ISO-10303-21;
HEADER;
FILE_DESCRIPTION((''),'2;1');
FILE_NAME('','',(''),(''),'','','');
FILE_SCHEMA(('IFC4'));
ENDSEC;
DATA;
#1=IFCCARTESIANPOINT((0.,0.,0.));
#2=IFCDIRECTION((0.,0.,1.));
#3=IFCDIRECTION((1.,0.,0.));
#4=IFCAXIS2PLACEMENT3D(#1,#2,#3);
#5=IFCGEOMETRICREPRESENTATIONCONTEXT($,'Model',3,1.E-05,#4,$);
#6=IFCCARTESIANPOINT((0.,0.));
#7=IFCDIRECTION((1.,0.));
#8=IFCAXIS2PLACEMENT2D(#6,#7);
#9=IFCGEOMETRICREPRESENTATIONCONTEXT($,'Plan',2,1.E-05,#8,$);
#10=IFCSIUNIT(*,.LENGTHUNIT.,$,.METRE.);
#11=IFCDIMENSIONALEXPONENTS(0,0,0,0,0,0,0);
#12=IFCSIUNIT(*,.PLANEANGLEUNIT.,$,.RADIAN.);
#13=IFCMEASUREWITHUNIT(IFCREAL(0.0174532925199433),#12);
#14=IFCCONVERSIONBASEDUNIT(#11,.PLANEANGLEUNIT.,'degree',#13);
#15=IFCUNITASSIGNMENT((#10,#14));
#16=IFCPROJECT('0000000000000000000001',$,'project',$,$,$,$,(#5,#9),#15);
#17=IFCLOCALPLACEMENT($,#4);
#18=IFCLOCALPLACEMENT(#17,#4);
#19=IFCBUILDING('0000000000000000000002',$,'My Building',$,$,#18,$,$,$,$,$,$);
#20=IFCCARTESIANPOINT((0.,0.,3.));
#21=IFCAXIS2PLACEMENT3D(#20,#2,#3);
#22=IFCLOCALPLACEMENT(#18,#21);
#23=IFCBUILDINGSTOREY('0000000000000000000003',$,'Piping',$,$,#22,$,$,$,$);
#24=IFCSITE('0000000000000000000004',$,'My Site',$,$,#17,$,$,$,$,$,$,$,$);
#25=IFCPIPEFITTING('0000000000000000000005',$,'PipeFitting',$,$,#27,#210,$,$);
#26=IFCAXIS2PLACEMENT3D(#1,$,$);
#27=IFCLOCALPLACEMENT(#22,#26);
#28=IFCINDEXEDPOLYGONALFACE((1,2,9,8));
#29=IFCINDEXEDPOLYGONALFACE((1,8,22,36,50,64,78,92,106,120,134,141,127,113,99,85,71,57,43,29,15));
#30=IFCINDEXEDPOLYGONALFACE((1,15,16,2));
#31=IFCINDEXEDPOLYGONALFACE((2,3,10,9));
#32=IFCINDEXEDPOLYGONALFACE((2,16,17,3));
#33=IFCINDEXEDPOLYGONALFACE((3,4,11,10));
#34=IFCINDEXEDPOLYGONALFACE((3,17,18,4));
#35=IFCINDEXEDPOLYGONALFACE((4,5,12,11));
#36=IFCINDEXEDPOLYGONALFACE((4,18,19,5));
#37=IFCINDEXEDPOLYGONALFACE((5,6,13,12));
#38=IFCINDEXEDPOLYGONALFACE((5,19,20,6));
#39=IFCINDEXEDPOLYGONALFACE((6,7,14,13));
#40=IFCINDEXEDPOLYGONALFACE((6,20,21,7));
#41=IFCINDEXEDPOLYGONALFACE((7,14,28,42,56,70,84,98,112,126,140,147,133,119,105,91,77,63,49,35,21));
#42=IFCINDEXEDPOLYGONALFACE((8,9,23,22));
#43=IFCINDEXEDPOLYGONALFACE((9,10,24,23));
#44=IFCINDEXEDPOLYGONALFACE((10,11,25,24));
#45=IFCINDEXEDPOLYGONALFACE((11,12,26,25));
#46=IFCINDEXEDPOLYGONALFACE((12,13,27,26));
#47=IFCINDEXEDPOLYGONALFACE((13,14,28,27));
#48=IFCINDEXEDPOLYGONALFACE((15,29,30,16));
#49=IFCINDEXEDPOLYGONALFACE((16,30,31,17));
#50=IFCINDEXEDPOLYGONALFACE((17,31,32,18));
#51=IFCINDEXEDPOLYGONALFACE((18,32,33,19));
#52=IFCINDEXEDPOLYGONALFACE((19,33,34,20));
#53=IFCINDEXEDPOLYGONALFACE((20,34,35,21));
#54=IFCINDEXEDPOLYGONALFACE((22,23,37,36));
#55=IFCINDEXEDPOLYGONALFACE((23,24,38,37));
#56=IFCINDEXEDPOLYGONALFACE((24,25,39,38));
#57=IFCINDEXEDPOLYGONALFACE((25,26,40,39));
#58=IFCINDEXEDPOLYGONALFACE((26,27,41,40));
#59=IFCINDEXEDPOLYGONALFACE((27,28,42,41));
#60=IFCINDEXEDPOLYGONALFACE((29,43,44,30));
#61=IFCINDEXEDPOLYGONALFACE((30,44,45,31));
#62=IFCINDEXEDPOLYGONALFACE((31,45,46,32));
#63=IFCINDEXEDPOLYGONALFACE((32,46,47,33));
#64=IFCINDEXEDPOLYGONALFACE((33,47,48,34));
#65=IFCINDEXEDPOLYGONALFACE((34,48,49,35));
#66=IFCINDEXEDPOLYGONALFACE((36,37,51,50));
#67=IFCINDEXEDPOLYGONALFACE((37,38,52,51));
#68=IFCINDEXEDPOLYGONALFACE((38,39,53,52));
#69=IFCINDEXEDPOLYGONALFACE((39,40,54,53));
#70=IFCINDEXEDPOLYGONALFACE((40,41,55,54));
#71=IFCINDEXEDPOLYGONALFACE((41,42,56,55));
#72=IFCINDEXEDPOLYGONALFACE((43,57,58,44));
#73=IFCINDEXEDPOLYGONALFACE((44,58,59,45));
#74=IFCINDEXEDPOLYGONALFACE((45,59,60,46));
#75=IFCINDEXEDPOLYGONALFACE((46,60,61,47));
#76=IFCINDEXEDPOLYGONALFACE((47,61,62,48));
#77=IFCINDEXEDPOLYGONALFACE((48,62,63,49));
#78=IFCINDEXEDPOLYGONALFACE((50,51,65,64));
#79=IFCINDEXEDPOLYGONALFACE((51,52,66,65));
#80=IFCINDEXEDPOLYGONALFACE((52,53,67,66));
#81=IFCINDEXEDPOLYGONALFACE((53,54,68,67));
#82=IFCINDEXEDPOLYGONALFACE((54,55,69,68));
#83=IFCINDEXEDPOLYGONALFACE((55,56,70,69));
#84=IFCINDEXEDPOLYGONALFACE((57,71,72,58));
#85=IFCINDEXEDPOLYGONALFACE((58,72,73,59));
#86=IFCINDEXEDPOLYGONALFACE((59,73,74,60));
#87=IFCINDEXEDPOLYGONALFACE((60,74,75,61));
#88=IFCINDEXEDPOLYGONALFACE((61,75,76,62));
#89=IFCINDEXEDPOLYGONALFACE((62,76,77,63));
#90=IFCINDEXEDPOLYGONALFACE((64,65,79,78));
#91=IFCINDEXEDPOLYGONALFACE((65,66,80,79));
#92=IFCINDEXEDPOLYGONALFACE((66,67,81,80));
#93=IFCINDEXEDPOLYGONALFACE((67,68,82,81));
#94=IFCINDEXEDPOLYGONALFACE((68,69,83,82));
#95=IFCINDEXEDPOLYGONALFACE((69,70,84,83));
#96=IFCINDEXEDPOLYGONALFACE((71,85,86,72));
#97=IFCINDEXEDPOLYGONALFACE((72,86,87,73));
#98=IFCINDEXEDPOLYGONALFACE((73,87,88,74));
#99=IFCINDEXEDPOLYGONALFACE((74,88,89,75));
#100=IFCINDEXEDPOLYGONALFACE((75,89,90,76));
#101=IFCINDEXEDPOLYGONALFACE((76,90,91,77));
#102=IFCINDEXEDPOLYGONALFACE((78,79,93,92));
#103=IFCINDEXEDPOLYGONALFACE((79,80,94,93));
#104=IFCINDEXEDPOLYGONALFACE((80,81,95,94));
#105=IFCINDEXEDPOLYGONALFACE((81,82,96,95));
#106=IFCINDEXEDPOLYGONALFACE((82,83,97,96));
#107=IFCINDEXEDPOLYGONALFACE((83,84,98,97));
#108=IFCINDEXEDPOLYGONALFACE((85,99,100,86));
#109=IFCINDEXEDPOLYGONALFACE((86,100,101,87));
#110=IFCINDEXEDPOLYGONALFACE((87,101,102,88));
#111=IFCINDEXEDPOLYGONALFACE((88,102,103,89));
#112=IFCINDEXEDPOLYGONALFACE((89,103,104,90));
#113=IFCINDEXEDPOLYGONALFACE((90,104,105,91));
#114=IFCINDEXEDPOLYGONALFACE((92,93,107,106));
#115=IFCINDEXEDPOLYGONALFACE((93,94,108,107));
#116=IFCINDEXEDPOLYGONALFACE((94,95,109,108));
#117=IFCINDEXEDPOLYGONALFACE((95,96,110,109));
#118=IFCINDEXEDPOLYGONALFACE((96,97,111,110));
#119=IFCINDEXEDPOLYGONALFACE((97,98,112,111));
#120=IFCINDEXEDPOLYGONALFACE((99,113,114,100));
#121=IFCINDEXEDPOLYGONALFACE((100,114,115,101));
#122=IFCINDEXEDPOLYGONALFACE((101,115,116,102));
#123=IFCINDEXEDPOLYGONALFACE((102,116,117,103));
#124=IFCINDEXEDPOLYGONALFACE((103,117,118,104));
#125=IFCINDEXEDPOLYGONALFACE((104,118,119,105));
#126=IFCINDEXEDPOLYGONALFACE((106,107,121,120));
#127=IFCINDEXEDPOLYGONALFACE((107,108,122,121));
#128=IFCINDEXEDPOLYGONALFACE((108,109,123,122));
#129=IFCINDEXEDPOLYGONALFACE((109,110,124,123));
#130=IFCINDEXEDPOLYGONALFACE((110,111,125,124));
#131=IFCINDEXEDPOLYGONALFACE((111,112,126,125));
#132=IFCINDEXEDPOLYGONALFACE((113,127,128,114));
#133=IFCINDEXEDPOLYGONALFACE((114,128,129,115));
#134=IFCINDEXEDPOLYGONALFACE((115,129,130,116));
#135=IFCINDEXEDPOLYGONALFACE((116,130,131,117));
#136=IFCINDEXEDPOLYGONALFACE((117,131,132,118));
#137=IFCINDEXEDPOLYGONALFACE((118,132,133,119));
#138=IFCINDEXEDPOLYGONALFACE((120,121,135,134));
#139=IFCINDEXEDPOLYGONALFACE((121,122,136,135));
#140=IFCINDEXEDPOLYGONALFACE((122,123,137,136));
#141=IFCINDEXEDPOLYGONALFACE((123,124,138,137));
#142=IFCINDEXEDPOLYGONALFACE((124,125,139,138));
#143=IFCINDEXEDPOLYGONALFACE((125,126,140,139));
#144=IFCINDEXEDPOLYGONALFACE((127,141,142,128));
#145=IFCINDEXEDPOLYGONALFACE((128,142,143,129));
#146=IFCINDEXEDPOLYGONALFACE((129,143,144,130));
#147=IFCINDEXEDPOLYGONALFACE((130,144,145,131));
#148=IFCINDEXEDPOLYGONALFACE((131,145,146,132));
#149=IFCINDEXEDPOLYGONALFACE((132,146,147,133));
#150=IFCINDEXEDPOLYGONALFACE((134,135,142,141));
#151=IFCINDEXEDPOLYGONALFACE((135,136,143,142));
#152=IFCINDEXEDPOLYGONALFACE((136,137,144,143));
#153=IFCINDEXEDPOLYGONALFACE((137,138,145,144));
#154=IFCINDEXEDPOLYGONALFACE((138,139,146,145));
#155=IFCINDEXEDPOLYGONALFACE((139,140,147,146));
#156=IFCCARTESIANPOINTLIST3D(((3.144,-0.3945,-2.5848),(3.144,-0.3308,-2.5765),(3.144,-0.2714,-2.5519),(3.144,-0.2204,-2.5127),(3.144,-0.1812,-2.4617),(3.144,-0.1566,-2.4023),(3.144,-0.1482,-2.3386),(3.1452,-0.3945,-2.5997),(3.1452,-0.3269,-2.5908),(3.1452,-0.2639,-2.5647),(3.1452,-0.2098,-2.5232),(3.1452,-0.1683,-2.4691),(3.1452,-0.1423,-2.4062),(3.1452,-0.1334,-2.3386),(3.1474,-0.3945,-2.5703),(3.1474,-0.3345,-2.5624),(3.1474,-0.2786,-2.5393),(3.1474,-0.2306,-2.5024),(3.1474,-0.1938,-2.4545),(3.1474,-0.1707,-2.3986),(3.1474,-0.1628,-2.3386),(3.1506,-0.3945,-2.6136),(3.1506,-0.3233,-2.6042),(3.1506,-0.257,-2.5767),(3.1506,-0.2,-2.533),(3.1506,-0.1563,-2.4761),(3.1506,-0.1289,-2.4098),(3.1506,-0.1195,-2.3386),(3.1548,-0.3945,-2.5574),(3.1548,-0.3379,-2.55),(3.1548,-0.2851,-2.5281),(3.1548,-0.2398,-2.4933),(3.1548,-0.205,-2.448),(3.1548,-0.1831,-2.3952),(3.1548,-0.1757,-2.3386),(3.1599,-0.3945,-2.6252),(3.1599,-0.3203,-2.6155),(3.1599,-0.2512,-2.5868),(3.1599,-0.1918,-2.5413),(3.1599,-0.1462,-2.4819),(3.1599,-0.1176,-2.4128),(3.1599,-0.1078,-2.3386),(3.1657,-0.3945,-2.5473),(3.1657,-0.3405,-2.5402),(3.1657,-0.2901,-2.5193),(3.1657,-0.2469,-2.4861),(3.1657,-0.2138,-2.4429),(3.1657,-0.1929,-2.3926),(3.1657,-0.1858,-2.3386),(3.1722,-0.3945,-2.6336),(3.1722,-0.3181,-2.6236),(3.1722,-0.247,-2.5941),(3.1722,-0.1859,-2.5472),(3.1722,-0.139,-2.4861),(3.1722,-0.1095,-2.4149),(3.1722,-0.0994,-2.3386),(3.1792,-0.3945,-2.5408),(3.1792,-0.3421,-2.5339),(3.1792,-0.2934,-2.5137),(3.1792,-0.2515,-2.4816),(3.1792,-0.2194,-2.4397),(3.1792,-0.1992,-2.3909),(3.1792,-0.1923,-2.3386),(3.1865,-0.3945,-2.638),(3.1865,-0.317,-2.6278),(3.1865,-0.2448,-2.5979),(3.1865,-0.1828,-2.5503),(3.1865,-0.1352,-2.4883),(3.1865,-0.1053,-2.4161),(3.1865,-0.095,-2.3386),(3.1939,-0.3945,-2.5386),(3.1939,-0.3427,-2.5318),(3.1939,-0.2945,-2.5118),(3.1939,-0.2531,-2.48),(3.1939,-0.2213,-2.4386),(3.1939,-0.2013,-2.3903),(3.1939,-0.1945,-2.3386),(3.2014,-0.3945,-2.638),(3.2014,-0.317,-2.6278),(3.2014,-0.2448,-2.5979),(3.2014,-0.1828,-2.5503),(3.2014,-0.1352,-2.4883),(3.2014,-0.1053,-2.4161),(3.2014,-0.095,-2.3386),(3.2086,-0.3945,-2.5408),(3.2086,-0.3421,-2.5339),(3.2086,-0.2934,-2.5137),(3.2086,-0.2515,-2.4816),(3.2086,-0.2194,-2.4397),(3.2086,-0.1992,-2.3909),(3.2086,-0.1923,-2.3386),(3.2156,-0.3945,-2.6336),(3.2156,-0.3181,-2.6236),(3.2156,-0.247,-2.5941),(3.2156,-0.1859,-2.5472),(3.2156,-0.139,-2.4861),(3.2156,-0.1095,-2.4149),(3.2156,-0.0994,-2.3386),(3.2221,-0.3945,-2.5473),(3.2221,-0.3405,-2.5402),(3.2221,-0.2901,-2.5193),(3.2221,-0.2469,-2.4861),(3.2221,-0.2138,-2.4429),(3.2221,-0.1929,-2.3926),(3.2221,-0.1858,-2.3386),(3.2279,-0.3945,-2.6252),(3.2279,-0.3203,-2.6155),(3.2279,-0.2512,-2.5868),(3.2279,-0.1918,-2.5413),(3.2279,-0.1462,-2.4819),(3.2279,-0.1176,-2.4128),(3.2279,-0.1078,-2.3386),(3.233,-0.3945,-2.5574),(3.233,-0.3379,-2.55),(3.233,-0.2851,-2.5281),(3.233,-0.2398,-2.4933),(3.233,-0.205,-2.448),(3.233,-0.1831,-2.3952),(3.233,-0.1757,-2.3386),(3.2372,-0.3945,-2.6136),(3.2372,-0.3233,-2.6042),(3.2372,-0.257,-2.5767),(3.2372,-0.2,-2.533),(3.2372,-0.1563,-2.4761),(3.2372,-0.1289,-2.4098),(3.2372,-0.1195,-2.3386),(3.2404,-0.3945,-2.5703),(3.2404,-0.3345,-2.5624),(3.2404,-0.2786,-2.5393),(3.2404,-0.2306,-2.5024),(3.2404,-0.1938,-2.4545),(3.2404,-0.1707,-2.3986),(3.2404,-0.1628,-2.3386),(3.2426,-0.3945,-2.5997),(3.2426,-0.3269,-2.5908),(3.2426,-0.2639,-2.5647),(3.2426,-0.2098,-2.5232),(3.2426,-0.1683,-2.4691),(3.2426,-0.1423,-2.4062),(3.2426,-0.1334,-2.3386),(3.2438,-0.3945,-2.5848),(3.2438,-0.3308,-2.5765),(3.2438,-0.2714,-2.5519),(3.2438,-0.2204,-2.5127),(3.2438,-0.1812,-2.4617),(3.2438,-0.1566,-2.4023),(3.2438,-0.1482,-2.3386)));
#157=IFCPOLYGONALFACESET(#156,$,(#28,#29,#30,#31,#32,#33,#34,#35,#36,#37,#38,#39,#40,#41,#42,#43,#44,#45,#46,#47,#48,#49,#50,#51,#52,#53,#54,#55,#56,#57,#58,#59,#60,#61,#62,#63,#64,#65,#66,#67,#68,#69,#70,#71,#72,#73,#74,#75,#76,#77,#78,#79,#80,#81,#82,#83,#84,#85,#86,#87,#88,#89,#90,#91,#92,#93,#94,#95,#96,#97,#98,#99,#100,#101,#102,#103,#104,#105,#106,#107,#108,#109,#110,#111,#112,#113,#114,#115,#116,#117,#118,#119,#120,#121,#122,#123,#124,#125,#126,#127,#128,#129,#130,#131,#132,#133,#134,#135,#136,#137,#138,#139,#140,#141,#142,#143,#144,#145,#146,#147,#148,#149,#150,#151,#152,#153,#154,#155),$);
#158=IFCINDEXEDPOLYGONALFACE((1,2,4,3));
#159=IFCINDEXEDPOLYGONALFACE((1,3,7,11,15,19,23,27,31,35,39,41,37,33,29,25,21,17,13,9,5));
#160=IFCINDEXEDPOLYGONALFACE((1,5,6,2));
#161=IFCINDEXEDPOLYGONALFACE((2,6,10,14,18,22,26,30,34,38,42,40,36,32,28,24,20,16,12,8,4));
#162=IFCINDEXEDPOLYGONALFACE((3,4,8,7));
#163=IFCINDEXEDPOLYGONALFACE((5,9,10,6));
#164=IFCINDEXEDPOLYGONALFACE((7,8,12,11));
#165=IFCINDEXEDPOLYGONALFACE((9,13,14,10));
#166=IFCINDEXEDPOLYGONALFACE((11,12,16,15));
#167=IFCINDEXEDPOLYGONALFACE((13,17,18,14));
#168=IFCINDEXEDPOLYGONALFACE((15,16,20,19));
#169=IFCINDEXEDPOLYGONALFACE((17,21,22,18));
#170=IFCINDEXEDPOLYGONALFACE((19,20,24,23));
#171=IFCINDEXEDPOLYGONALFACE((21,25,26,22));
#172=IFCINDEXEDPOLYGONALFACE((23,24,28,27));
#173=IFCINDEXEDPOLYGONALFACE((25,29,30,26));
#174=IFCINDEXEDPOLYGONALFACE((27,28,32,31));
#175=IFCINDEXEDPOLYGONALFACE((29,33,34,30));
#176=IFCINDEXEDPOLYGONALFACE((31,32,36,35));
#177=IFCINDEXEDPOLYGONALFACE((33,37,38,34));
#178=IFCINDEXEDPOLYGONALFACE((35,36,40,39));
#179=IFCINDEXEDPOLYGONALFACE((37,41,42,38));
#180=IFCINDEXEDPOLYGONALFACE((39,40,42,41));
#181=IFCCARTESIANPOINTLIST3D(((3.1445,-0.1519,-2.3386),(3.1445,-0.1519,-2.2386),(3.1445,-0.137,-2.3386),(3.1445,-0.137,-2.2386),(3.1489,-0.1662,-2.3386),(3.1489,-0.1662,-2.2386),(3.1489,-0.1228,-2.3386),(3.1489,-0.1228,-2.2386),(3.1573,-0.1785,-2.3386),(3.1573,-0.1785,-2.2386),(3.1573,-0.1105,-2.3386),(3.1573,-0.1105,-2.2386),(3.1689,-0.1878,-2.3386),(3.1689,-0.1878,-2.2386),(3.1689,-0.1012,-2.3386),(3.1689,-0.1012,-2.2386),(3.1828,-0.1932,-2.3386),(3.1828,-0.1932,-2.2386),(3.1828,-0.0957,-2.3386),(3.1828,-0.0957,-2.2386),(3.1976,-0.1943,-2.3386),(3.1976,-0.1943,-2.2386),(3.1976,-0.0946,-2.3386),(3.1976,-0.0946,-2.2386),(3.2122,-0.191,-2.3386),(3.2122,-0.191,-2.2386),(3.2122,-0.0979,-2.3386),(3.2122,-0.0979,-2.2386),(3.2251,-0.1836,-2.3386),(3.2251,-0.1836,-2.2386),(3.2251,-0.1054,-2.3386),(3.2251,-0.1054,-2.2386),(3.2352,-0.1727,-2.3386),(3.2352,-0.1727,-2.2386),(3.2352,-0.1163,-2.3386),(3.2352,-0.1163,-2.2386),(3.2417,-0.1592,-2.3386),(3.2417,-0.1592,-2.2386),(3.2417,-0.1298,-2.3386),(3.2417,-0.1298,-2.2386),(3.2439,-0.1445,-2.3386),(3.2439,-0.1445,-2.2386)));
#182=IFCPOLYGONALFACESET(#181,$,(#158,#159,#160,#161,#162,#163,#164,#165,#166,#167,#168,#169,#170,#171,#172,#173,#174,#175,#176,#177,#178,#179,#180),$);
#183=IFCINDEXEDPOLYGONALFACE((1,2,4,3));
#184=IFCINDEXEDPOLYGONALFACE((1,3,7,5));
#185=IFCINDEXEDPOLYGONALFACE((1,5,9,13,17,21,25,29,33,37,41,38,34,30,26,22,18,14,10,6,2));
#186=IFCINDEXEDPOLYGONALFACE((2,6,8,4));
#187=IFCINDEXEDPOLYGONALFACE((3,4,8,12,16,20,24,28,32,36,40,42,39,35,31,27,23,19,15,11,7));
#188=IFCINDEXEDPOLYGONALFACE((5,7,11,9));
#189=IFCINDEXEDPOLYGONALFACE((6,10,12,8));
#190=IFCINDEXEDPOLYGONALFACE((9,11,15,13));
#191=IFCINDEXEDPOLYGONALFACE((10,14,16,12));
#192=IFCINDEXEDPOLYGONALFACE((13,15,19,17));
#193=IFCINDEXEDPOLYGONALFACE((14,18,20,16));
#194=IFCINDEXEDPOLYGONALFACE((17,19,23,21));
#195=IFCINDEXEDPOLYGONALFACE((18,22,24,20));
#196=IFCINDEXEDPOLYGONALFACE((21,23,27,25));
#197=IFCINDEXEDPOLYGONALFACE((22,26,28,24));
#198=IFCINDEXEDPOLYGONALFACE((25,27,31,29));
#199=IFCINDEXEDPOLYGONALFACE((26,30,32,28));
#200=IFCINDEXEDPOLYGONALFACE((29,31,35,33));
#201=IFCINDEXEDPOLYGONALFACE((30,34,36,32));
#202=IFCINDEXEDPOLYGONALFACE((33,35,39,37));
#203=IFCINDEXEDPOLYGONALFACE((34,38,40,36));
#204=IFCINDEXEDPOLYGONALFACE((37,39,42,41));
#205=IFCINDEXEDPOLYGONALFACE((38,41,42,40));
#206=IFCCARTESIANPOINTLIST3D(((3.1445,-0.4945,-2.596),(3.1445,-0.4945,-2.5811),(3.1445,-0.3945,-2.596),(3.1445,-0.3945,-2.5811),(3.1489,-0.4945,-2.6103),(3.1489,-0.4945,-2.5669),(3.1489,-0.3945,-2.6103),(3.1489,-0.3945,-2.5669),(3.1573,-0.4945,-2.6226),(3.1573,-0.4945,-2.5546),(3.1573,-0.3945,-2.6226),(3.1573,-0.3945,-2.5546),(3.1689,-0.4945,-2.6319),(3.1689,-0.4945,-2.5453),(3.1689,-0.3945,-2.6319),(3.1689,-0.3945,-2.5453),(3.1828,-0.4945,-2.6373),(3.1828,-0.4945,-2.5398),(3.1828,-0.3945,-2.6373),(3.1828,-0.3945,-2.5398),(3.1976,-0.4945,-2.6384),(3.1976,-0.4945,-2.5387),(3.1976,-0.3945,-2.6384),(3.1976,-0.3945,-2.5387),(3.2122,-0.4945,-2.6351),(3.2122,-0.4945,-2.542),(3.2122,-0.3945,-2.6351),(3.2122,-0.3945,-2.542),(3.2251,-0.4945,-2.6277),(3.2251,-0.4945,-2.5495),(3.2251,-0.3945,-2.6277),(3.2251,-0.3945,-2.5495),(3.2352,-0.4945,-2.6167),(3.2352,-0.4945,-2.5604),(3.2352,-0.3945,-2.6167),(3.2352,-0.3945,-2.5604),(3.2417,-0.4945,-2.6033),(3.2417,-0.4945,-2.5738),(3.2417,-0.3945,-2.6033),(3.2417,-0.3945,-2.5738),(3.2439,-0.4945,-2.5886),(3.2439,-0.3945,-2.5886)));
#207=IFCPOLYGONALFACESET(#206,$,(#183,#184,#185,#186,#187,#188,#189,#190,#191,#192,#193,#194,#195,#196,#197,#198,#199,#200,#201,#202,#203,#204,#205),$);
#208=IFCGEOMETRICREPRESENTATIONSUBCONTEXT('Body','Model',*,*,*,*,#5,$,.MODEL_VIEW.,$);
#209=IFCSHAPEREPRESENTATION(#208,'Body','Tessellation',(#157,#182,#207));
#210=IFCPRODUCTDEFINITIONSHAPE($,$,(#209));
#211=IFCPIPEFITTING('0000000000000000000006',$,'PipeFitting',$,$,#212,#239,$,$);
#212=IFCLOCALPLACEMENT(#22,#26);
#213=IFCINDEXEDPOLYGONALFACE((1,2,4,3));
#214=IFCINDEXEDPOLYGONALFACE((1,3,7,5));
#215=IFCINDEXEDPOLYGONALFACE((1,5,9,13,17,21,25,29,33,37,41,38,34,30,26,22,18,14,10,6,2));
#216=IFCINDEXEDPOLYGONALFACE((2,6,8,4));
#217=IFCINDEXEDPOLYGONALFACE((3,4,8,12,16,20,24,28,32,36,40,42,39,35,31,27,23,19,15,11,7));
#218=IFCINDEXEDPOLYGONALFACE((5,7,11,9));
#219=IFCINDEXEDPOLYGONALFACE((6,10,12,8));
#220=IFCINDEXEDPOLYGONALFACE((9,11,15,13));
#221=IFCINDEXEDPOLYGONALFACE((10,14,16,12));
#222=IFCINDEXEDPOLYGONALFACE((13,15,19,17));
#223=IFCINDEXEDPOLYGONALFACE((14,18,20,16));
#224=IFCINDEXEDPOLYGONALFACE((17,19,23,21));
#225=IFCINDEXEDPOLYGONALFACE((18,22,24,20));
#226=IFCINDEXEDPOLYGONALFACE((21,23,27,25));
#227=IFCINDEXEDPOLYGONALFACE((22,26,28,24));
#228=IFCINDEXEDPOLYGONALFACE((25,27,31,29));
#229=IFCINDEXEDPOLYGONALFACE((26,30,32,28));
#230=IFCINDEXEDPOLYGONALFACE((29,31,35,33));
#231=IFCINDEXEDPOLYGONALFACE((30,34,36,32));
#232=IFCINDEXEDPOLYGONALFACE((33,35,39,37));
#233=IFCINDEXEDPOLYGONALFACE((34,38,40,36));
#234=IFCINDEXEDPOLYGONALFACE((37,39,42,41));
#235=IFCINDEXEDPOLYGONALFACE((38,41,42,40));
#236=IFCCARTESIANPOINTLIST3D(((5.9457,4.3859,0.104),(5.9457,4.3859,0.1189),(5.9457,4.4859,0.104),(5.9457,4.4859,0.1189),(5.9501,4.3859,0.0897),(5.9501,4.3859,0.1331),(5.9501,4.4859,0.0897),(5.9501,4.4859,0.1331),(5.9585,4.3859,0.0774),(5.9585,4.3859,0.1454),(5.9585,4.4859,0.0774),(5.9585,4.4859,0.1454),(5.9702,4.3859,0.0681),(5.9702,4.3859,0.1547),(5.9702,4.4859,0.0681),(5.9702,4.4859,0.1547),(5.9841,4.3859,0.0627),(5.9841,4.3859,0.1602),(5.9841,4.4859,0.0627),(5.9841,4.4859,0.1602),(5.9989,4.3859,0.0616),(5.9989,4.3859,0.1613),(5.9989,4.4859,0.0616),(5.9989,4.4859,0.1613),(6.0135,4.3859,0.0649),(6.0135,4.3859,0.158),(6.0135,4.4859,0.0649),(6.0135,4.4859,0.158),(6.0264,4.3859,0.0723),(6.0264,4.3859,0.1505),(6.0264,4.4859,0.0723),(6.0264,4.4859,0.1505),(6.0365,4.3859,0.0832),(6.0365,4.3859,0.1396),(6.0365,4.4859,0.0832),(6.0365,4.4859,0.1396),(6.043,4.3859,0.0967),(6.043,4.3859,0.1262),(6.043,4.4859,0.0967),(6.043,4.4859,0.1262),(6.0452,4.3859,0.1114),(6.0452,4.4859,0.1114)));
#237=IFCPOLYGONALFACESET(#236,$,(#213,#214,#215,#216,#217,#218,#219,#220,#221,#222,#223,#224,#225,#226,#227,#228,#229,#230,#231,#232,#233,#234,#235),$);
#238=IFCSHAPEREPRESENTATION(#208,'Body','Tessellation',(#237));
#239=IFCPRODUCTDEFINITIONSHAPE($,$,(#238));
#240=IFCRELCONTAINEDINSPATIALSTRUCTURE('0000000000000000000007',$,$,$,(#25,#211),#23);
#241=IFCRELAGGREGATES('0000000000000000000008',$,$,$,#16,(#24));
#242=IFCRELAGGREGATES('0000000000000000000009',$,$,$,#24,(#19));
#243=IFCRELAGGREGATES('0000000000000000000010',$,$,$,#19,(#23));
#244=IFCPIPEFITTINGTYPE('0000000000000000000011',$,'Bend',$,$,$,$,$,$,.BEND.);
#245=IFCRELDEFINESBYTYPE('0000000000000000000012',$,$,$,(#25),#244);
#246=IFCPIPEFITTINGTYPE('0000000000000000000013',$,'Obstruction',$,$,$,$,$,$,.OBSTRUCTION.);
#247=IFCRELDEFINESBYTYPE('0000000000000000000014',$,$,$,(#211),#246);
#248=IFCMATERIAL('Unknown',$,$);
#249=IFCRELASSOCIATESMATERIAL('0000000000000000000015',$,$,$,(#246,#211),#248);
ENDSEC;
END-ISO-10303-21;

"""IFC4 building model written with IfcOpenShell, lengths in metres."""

from ifc_helpers import new_model, entity, si_unit, converted_unit, frame, origin_with_axes, origin_2d_with_axis, place, context, subcontext, project, spatial, circle, extrude, source, transform, mapped, material, material_profile, profile_set, profile_usage, type_object, type_shapes, element, save


model = new_model("IFC4")

# Units and contexts
model_context = context("Model", 3, precision=1e-05, world=origin_with_axes())
plan_context = context("Plan", 2, precision=1e-05, world=origin_2d_with_axis())
body_context = subcontext(model_context, "Body", "Model", "MODEL_VIEW")
ifc_project = project(units=[si_unit("LENGTHUNIT", "METRE"), converted_unit("PLANEANGLEUNIT", "degree", entity("IfcReal", 0.0174532925199433), si_unit("PLANEANGLEUNIT", "RADIAN"), dimensions=[0, 0, 0, 0, 0, 0, 0])], contexts=[model_context, plan_context])

# Site, building, storey
site_placement = place(None, origin_with_axes())
site = spatial("IfcSite", under=ifc_project, at=site_placement, Name="My Site")
building_placement = place(site_placement, origin_with_axes())
building = spatial("IfcBuilding", under=site, at=building_placement, Name="My Building")
storey_placement = place(building_placement, frame((0.0, 0.0, 3.0), z_axis=(0.0, 0.0, 1.0), x_axis=(1.0, 0.0, 0.0)))
storey = spatial("IfcBuildingStorey", under=building, at=storey_placement, Name="Piping")

# Shared definitions
ifc_material = material(Name="Unknown")

# Pipe fittings
pipe_fitting_type_1 = type_object("IfcPipeFittingType", Name="Bend", PredefinedType="BEND")
shared_shape = source(origin_with_axes(), body_context, "Body", "SolidModel", [
    entity("IfcSweptDiskSolid", entity("IfcIndexedPolyCurve", entity("IfcCartesianPointList3D", [[0.0, 0.0, -0.1], [0.0, -0.0732, -0.2768], [0.0, -0.25, -0.35]]), [entity("IfcArcIndex", [1, 2, 3])]), 0.05),
    extrude(circle(Radius=0.05), origin_with_axes(), (0.0, 0.0, -1.0), 0.1),
    extrude(circle(Radius=0.05), frame((0.0, -0.25, -0.35), z_axis=(0.0, -1.0, 0.0), x_axis=(1.0, 0.0, 0.0)), (0.0, 0.0, 1.0), 0.1),
])
type_shapes(pipe_fitting_type_1, [shared_shape])
for number, where, z_axis, x_axis, name in (
    (1, (3.1939, -0.1445, -2.2386), (0.0, 0.0, 1.0), (1.0, 0.0, 0.0), "PipeFitting"),
):
    element("IfcPipeFitting", number, at=place(storey_placement, frame(where, z_axis=z_axis, x_axis=x_axis)), inside=storey, type_object=pipe_fitting_type_1, Name=name, context=body_context, shape_type="MappedRepresentation", body=[
        mapped(shared_shape, transform((0.0, 0.0, 0.0), x_axis=(1.0, 0.0, 0.0), y_axis=(0.0, 1.0, 0.0), z_axis=(0.0, 0.0, 1.0), scale=1.0)),
    ])
ifc_material_profile_1 = material_profile(ifc_material, circle(Radius=0.05))
ifc_profile_set_1 = profile_set([ifc_material_profile_1])
ifc_profile_usage_1 = profile_usage(ifc_profile_set_1, cardinal=16)
pipe_fitting_type_2 = type_object("IfcPipeFittingType", Name="Obstruction", PredefinedType="OBSTRUCTION", material=ifc_profile_set_1)
pipe_fitting_1_placement = place(storey_placement, frame((5.9952, 4.4859, 0.1114), z_axis=(0.0, -1.0, 0.0), x_axis=(1.0, 0.0, 0.0)))
element("IfcPipeFitting", 2, at=pipe_fitting_1_placement, inside=storey, type_object=pipe_fitting_type_2, material=ifc_profile_usage_1, Name="PipeFitting", context=body_context, shape_type="SweptSolid", body=[
    extrude(circle(Radius=0.05), origin_with_axes(), (0.0, 0.0, 1.0), 0.1),
])

save(model, "model.ifc")
